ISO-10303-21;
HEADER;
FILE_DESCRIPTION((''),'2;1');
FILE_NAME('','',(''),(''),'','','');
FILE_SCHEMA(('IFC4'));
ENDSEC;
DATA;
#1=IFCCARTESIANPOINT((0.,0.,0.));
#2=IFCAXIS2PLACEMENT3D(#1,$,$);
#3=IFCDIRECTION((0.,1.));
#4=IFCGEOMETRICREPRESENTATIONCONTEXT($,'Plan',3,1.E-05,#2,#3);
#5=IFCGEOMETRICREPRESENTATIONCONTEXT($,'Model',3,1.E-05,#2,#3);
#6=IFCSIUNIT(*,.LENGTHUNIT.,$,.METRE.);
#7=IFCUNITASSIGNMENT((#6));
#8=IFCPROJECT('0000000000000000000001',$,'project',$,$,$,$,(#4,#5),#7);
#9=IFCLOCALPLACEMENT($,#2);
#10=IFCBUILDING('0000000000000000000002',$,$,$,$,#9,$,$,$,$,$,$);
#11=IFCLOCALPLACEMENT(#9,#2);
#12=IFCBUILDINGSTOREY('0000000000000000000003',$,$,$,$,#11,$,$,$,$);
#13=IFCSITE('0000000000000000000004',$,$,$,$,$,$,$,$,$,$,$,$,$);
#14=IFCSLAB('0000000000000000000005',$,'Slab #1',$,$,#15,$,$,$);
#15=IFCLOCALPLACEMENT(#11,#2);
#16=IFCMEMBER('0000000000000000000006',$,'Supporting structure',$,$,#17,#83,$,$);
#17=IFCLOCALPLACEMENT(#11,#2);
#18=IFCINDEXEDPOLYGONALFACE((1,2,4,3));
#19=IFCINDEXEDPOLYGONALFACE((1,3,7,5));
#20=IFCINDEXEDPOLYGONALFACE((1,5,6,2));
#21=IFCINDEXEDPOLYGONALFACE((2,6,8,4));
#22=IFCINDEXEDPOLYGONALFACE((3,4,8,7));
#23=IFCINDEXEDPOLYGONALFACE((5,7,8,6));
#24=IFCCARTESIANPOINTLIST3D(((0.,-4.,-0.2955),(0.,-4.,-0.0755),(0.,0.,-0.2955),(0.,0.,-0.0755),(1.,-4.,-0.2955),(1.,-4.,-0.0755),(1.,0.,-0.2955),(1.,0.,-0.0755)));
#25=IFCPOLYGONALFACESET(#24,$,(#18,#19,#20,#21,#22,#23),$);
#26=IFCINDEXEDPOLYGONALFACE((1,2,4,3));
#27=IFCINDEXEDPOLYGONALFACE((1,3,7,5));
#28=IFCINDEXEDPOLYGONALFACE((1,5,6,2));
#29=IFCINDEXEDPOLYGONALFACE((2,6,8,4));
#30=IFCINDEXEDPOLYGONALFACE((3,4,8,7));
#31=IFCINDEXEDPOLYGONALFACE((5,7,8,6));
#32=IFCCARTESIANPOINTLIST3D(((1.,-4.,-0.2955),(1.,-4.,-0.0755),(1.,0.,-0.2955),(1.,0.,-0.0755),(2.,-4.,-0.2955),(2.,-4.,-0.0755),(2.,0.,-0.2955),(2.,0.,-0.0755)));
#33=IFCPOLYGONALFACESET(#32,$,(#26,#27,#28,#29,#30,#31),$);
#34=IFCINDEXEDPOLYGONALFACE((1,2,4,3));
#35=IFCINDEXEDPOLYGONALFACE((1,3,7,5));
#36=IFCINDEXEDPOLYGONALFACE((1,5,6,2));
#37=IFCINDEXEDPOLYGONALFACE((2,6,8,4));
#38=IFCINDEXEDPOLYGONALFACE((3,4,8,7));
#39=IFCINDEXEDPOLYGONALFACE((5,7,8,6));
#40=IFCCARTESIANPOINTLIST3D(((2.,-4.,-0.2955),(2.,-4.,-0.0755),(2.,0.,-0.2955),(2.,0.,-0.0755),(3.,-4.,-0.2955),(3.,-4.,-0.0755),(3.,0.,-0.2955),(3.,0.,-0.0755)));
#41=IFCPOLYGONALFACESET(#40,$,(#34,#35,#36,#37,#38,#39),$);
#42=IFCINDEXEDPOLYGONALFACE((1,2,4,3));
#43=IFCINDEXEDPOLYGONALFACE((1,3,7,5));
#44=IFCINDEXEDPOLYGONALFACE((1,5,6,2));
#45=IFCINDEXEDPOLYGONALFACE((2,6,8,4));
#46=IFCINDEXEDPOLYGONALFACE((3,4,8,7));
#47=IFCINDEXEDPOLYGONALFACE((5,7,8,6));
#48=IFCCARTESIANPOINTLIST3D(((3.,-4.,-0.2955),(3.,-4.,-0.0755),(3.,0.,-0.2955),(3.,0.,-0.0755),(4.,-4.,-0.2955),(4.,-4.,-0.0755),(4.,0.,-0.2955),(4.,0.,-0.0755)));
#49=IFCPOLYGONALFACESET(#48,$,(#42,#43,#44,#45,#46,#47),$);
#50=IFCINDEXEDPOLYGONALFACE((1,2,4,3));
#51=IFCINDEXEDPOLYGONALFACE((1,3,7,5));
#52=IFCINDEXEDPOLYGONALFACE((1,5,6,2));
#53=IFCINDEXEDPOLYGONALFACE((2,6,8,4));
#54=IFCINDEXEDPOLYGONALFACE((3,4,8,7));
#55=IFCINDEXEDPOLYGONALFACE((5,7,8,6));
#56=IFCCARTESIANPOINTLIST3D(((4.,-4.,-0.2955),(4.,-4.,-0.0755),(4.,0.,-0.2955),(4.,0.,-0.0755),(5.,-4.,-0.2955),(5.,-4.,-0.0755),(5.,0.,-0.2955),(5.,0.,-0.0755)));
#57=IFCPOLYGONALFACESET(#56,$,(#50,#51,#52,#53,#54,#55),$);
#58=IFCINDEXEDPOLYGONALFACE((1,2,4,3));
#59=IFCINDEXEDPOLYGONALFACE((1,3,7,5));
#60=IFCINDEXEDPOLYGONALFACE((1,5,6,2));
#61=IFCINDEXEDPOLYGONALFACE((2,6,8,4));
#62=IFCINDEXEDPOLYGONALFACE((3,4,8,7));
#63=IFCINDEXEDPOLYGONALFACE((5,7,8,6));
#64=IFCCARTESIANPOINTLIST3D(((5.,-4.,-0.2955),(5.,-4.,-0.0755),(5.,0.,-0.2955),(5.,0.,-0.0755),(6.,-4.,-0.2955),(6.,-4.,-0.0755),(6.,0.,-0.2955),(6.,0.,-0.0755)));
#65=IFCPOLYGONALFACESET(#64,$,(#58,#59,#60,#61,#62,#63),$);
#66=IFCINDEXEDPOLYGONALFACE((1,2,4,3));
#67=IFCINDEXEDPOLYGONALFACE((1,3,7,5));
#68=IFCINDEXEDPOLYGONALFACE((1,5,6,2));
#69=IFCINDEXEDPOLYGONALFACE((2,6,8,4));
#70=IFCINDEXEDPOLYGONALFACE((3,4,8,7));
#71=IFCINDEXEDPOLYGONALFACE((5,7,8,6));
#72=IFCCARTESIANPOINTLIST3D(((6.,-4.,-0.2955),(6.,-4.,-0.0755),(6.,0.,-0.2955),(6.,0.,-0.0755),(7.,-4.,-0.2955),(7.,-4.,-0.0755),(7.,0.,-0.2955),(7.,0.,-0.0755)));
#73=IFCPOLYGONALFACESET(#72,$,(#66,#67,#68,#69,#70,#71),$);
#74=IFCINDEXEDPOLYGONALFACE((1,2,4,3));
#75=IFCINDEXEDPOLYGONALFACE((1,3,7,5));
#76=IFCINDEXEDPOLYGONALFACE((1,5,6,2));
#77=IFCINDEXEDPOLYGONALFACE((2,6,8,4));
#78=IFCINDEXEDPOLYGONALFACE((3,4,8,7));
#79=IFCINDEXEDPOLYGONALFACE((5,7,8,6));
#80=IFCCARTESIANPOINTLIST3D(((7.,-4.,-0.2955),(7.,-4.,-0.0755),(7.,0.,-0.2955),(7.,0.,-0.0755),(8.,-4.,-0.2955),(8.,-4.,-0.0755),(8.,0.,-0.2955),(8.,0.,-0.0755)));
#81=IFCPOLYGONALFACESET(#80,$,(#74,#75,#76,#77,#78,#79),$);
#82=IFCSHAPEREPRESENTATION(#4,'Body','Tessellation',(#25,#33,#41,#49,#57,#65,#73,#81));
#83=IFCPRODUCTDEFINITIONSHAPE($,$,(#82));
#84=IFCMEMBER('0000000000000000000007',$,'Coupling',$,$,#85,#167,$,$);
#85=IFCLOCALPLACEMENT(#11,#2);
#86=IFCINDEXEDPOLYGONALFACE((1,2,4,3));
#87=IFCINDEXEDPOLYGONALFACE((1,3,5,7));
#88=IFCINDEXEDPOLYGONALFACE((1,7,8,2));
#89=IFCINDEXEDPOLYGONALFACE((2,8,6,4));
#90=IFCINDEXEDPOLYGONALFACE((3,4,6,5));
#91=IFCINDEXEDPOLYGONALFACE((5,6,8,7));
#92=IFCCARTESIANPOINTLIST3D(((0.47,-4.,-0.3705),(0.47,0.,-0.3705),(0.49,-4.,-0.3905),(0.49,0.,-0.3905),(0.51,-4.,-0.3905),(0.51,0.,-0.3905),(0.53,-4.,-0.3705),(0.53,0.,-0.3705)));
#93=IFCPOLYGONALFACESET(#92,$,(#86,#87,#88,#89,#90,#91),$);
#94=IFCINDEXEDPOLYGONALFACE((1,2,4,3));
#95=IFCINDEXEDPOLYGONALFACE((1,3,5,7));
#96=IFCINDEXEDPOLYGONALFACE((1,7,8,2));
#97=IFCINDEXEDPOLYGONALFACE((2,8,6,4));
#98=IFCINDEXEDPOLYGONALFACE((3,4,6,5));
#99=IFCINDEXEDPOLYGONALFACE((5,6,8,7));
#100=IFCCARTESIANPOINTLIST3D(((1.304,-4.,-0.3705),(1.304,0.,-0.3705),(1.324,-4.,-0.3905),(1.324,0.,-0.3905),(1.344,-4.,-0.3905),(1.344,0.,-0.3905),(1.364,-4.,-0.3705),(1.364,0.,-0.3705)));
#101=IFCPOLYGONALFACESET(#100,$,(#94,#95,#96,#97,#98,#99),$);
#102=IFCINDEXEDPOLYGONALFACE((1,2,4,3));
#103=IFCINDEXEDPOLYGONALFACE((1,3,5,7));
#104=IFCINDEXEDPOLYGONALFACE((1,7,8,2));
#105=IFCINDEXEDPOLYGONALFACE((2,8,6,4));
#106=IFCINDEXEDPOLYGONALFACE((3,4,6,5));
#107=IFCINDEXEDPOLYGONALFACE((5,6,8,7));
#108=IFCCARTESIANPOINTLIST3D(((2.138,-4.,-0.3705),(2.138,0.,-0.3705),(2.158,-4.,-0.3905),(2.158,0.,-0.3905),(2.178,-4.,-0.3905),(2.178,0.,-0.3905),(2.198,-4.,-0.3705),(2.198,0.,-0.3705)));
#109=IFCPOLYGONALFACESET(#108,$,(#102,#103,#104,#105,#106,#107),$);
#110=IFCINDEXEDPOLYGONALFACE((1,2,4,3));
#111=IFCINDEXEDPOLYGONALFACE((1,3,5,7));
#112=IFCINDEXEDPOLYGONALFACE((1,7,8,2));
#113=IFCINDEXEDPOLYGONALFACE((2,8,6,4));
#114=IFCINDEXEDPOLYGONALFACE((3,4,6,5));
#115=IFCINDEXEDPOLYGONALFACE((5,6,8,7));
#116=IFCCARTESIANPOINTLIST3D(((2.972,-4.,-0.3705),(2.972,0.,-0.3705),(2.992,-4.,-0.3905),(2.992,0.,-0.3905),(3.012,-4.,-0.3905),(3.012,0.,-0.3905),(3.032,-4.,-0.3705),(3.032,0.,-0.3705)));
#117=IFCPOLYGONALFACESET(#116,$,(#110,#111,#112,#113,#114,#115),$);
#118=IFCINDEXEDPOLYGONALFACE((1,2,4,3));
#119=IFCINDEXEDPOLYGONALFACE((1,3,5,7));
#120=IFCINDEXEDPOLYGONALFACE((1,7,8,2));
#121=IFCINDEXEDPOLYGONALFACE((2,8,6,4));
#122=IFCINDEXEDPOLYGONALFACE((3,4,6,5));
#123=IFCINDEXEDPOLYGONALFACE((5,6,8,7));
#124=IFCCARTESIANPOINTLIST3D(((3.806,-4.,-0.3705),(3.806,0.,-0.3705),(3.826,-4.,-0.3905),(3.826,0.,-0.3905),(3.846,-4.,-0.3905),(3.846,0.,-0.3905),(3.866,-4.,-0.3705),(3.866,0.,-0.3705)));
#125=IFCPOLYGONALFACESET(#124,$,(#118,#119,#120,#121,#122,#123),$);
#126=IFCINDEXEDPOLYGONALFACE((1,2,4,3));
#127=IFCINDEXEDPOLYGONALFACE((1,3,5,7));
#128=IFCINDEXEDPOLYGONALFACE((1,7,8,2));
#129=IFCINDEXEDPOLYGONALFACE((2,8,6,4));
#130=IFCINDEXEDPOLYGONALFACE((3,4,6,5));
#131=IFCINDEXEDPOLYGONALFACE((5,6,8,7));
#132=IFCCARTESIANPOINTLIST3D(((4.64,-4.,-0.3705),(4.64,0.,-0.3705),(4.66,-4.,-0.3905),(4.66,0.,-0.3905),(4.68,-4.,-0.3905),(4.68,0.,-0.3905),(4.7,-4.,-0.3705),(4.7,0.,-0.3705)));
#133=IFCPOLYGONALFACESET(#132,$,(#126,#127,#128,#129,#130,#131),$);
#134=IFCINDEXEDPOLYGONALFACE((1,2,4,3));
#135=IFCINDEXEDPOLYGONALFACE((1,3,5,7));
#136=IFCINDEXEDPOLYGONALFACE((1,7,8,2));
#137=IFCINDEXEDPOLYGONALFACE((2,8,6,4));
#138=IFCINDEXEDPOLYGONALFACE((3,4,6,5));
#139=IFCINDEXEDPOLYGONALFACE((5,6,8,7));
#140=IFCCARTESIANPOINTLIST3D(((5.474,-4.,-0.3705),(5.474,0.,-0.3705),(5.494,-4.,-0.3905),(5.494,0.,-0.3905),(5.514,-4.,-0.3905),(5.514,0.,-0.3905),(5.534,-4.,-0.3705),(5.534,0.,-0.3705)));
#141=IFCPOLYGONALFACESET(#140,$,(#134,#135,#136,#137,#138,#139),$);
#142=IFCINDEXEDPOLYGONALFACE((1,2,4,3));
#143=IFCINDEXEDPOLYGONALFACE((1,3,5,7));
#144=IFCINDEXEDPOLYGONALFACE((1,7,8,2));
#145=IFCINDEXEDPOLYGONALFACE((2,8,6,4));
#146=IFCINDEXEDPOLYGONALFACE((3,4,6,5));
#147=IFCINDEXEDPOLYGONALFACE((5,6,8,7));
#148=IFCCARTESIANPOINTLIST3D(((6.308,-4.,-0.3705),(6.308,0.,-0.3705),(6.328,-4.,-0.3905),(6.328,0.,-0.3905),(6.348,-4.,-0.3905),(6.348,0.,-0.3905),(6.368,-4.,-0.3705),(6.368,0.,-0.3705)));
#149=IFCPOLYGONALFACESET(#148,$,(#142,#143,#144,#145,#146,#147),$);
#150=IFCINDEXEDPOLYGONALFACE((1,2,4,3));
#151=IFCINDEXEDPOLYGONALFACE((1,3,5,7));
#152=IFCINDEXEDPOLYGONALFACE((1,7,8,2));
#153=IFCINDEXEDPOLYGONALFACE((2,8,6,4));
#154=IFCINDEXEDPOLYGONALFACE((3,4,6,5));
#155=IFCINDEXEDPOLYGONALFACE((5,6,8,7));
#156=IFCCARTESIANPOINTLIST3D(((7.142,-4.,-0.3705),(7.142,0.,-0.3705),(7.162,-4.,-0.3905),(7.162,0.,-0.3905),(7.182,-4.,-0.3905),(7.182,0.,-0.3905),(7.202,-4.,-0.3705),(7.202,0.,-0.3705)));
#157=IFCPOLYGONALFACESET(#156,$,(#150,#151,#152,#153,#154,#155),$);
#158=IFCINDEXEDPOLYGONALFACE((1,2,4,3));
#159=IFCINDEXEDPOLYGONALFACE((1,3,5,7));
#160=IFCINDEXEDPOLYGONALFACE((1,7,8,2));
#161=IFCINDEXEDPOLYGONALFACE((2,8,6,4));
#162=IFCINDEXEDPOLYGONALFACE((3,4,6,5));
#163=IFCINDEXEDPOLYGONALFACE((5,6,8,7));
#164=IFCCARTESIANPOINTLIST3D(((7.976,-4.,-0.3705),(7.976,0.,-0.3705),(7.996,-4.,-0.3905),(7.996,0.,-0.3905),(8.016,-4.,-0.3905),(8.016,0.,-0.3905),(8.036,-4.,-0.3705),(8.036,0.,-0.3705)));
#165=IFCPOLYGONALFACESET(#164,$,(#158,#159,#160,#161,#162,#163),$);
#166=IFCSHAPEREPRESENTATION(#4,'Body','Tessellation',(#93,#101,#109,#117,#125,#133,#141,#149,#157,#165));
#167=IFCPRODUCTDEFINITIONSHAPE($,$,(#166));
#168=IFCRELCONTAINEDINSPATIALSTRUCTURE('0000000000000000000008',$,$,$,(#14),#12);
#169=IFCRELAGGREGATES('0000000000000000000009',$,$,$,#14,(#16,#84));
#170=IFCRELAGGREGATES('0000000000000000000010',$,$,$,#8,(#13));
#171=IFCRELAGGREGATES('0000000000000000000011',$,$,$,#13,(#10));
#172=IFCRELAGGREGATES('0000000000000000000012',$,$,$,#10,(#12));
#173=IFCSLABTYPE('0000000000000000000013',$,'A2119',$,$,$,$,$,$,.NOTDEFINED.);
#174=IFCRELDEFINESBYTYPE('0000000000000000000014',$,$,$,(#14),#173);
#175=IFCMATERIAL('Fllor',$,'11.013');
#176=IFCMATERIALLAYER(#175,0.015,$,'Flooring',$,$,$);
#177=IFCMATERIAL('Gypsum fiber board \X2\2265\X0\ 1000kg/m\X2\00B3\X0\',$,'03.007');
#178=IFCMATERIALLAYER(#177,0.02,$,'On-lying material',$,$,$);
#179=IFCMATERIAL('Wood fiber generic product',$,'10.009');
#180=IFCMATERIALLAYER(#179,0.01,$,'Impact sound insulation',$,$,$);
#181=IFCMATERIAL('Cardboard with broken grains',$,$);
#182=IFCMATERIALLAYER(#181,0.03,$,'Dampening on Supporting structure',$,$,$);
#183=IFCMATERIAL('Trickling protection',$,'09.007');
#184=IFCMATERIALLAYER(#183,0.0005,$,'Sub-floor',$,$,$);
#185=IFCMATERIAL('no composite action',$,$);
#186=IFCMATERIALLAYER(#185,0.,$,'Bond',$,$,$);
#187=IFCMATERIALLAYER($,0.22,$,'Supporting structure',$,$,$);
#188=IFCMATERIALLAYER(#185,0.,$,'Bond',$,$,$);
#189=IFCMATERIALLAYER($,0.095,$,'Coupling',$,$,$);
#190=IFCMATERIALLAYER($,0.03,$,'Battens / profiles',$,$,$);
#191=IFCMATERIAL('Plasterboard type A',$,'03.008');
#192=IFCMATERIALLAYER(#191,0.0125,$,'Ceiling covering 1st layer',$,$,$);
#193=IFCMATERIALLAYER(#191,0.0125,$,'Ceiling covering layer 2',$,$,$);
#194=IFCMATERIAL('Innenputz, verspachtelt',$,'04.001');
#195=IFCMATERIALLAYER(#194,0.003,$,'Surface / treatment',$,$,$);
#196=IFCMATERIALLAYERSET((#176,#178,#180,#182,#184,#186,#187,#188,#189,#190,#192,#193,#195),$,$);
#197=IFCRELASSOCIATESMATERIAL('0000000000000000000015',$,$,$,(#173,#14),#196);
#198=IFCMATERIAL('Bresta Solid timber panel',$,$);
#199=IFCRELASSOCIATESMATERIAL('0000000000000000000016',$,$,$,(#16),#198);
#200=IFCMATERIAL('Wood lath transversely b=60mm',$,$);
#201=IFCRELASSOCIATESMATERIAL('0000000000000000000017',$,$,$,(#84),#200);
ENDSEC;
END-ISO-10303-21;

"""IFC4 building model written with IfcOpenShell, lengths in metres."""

from ifc_helpers import new_model, si_unit, direction, frame, frame_2d, origin, place, context, project, spatial, polyline, rectangle, outline, extrude, material, layer, layer_set, type_object, element, aggregate, save


model = new_model("IFC4")

# Units and contexts
plan_context = context("Plan", 3, precision=1e-05, world=origin(), true_north=direction((0.0, 1.0)))
model_context = context("Model", 3, precision=1e-05, world=origin(), true_north=direction((0.0, 1.0)))
ifc_project = project(units=[si_unit("LENGTHUNIT", "METRE")], contexts=[plan_context, model_context])

# Site, building, storey
site = spatial("IfcSite", under=ifc_project)
building_placement = place(None, origin())
building = spatial("IfcBuilding", under=site, at=building_placement)
storey_placement = place(building_placement, origin())
storey = spatial("IfcBuildingStorey", under=building, at=storey_placement)

# Slab, members
ifc_material_1 = material(Name="Fllor", Category="11.013")
ifc_layer_1 = layer(ifc_material_1, 0.015, Name="Flooring")
ifc_material_2 = material(Name="Gypsum fiber board ≥ 1000kg/m³", Category="03.007")
ifc_layer_2 = layer(ifc_material_2, 0.02, Name="On-lying material")
ifc_material_3 = material(Name="Wood fiber generic product", Category="10.009")
ifc_layer_3 = layer(ifc_material_3, 0.01, Name="Impact sound insulation")
ifc_material_4 = material(Name="Cardboard with broken grains")
ifc_layer_4 = layer(ifc_material_4, 0.03, Name="Dampening on Supporting structure")
ifc_material_5 = material(Name="Trickling protection", Category="09.007")
ifc_layer_5 = layer(ifc_material_5, 0.0005, Name="Sub-floor")
ifc_material_6 = material(Name="no composite action")
ifc_layer_6 = layer(ifc_material_6, 0.0, Name="Bond")
ifc_layer_7 = layer(None, 0.22, Name="Supporting structure")
ifc_layer_8 = layer(ifc_material_6, 0.0, Name="Bond")
ifc_layer_9 = layer(None, 0.095, Name="Coupling")
ifc_layer_10 = layer(None, 0.03, Name="Battens / profiles")
ifc_material_7 = material(Name="Plasterboard type A", Category="03.008")
ifc_layer_11 = layer(ifc_material_7, 0.0125, Name="Ceiling covering 1st layer")
ifc_layer_12 = layer(ifc_material_7, 0.0125, Name="Ceiling covering layer 2")
ifc_material_8 = material(Name="Innenputz, verspachtelt", Category="04.001")
ifc_layer_13 = layer(ifc_material_8, 0.003, Name="Surface / treatment")
ifc_layer_set = layer_set([ifc_layer_1, ifc_layer_2, ifc_layer_3, ifc_layer_4, ifc_layer_5, ifc_layer_6, ifc_layer_7, ifc_layer_8, ifc_layer_9, ifc_layer_10, ifc_layer_11, ifc_layer_12, ifc_layer_13])
slab_type = type_object("IfcSlabType", Name="A2119", PredefinedType="NOTDEFINED", material=ifc_layer_set)
slab_placement = place(None, frame((0.0, 0.0, 0.0), z_axis=(0.0, 0.0, -1.0), x_axis=(1.0, 0.0, 0.0)))
slab = element("IfcSlab", 1, at=slab_placement, inside=storey, type_object=slab_type, material=ifc_layer_set, Name="Slab #1")
ifc_material_9 = material(Name="Bresta Solid timber panel")
member_1_placement = place(slab_placement, origin())
member_1 = element("IfcMember", 2, at=member_1_placement, material=ifc_material_9, Name="Supporting structure", context=plan_context, shape_type="SweptSolid", body=[
    extrude(rectangle(XDim=1.0, YDim=0.22, at=frame_2d((0.5, 0.11), x_axis=(1.0, 0.0))), frame((0.0, 4.0, 0.0755), z_axis=(0.0, -1.0, 0.0), x_axis=(1.0, 0.0, 0.0)), (0.0, 0.0, 1.0), 4.0),
    extrude(rectangle(XDim=1.0, YDim=0.22, at=frame_2d((0.5, 0.11), x_axis=(1.0, 0.0))), frame((1.0, 4.0, 0.0755), z_axis=(0.0, -1.0, 0.0), x_axis=(1.0, 0.0, 0.0)), (0.0, 0.0, 1.0), 4.0),
    extrude(rectangle(XDim=1.0, YDim=0.22, at=frame_2d((0.5, 0.11), x_axis=(1.0, 0.0))), frame((2.0, 4.0, 0.0755), z_axis=(0.0, -1.0, 0.0), x_axis=(1.0, 0.0, 0.0)), (0.0, 0.0, 1.0), 4.0),
    extrude(rectangle(XDim=1.0, YDim=0.22, at=frame_2d((0.5, 0.11), x_axis=(1.0, 0.0))), frame((3.0, 4.0, 0.0755), z_axis=(0.0, -1.0, 0.0), x_axis=(1.0, 0.0, 0.0)), (0.0, 0.0, 1.0), 4.0),
    extrude(rectangle(XDim=1.0, YDim=0.22, at=frame_2d((0.5, 0.11), x_axis=(1.0, 0.0))), frame((4.0, 4.0, 0.0755), z_axis=(0.0, -1.0, 0.0), x_axis=(1.0, 0.0, 0.0)), (0.0, 0.0, 1.0), 4.0),
    extrude(rectangle(XDim=1.0, YDim=0.22, at=frame_2d((0.5, 0.11), x_axis=(1.0, 0.0))), frame((5.0, 4.0, 0.0755), z_axis=(0.0, -1.0, 0.0), x_axis=(1.0, 0.0, 0.0)), (0.0, 0.0, 1.0), 4.0),
    extrude(rectangle(XDim=1.0, YDim=0.22, at=frame_2d((0.5, 0.11), x_axis=(1.0, 0.0))), frame((6.0, 4.0, 0.0755), z_axis=(0.0, -1.0, 0.0), x_axis=(1.0, 0.0, 0.0)), (0.0, 0.0, 1.0), 4.0),
    extrude(rectangle(XDim=1.0, YDim=0.22, at=frame_2d((0.5, 0.11), x_axis=(1.0, 0.0))), frame((7.0, 4.0, 0.0755), z_axis=(0.0, -1.0, 0.0), x_axis=(1.0, 0.0, 0.0)), (0.0, 0.0, 1.0), 4.0),
])
ifc_material_10 = material(Name="Wood lath transversely b=60mm")
member_2_placement = place(slab_placement, origin())
member_2 = element("IfcMember", 3, at=member_2_placement, material=ifc_material_10, Name="Coupling", context=plan_context, shape_type="SweptSolid", body=[
    extrude(outline(polyline([(0.0, 0.0), (0.06, 0.0), (0.04, 0.02), (0.02, 0.02), (0.0, 0.0)])), frame((0.47, 4.0, 0.3705), z_axis=(0.0, -1.0, 0.0), x_axis=(1.0, 0.0, 0.0)), (0.0, 0.0, 1.0), 4.0),
    extrude(outline(polyline([(0.0, 0.0), (0.06, 0.0), (0.04, 0.02), (0.02, 0.02), (0.0, 0.0)])), frame((1.304, 4.0, 0.3705), z_axis=(0.0, -1.0, 0.0), x_axis=(1.0, 0.0, 0.0)), (0.0, 0.0, 1.0), 4.0),
    extrude(outline(polyline([(0.0, 0.0), (0.06, 0.0), (0.04, 0.02), (0.02, 0.02), (0.0, 0.0)])), frame((2.138, 4.0, 0.3705), z_axis=(0.0, -1.0, 0.0), x_axis=(1.0, 0.0, 0.0)), (0.0, 0.0, 1.0), 4.0),
    extrude(outline(polyline([(0.0, 0.0), (0.06, 0.0), (0.04, 0.02), (0.02, 0.02), (0.0, 0.0)])), frame((2.972, 4.0, 0.3705), z_axis=(0.0, -1.0, 0.0), x_axis=(1.0, 0.0, 0.0)), (0.0, 0.0, 1.0), 4.0),
    extrude(outline(polyline([(0.0, 0.0), (0.06, 0.0), (0.04, 0.02), (0.02, 0.02), (0.0, 0.0)])), frame((3.806, 4.0, 0.3705), z_axis=(0.0, -1.0, 0.0), x_axis=(1.0, 0.0, 0.0)), (0.0, 0.0, 1.0), 4.0),
    extrude(outline(polyline([(0.0, 0.0), (0.06, 0.0), (0.04, 0.02), (0.02, 0.02), (0.0, 0.0)])), frame((4.64, 4.0, 0.3705), z_axis=(0.0, -1.0, 0.0), x_axis=(1.0, 0.0, 0.0)), (0.0, 0.0, 1.0), 4.0),
    extrude(outline(polyline([(0.0, 0.0), (0.06, 0.0), (0.04, 0.02), (0.02, 0.02), (0.0, 0.0)])), frame((5.474, 4.0, 0.3705), z_axis=(0.0, -1.0, 0.0), x_axis=(1.0, 0.0, 0.0)), (0.0, 0.0, 1.0), 4.0),
    extrude(outline(polyline([(0.0, 0.0), (0.06, 0.0), (0.04, 0.02), (0.02, 0.02), (0.0, 0.0)])), frame((6.308, 4.0, 0.3705), z_axis=(0.0, -1.0, 0.0), x_axis=(1.0, 0.0, 0.0)), (0.0, 0.0, 1.0), 4.0),
    extrude(outline(polyline([(0.0, 0.0), (0.06, 0.0), (0.04, 0.02), (0.02, 0.02), (0.0, 0.0)])), frame((7.142, 4.0, 0.3705), z_axis=(0.0, -1.0, 0.0), x_axis=(1.0, 0.0, 0.0)), (0.0, 0.0, 1.0), 4.0),
    extrude(outline(polyline([(0.0, 0.0), (0.06, 0.0), (0.04, 0.02), (0.02, 0.02), (0.0, 0.0)])), frame((7.976, 4.0, 0.3705), z_axis=(0.0, -1.0, 0.0), x_axis=(1.0, 0.0, 0.0)), (0.0, 0.0, 1.0), 4.0),
])
aggregate(slab, [member_1, member_2])

save(model, "model.ifc")
